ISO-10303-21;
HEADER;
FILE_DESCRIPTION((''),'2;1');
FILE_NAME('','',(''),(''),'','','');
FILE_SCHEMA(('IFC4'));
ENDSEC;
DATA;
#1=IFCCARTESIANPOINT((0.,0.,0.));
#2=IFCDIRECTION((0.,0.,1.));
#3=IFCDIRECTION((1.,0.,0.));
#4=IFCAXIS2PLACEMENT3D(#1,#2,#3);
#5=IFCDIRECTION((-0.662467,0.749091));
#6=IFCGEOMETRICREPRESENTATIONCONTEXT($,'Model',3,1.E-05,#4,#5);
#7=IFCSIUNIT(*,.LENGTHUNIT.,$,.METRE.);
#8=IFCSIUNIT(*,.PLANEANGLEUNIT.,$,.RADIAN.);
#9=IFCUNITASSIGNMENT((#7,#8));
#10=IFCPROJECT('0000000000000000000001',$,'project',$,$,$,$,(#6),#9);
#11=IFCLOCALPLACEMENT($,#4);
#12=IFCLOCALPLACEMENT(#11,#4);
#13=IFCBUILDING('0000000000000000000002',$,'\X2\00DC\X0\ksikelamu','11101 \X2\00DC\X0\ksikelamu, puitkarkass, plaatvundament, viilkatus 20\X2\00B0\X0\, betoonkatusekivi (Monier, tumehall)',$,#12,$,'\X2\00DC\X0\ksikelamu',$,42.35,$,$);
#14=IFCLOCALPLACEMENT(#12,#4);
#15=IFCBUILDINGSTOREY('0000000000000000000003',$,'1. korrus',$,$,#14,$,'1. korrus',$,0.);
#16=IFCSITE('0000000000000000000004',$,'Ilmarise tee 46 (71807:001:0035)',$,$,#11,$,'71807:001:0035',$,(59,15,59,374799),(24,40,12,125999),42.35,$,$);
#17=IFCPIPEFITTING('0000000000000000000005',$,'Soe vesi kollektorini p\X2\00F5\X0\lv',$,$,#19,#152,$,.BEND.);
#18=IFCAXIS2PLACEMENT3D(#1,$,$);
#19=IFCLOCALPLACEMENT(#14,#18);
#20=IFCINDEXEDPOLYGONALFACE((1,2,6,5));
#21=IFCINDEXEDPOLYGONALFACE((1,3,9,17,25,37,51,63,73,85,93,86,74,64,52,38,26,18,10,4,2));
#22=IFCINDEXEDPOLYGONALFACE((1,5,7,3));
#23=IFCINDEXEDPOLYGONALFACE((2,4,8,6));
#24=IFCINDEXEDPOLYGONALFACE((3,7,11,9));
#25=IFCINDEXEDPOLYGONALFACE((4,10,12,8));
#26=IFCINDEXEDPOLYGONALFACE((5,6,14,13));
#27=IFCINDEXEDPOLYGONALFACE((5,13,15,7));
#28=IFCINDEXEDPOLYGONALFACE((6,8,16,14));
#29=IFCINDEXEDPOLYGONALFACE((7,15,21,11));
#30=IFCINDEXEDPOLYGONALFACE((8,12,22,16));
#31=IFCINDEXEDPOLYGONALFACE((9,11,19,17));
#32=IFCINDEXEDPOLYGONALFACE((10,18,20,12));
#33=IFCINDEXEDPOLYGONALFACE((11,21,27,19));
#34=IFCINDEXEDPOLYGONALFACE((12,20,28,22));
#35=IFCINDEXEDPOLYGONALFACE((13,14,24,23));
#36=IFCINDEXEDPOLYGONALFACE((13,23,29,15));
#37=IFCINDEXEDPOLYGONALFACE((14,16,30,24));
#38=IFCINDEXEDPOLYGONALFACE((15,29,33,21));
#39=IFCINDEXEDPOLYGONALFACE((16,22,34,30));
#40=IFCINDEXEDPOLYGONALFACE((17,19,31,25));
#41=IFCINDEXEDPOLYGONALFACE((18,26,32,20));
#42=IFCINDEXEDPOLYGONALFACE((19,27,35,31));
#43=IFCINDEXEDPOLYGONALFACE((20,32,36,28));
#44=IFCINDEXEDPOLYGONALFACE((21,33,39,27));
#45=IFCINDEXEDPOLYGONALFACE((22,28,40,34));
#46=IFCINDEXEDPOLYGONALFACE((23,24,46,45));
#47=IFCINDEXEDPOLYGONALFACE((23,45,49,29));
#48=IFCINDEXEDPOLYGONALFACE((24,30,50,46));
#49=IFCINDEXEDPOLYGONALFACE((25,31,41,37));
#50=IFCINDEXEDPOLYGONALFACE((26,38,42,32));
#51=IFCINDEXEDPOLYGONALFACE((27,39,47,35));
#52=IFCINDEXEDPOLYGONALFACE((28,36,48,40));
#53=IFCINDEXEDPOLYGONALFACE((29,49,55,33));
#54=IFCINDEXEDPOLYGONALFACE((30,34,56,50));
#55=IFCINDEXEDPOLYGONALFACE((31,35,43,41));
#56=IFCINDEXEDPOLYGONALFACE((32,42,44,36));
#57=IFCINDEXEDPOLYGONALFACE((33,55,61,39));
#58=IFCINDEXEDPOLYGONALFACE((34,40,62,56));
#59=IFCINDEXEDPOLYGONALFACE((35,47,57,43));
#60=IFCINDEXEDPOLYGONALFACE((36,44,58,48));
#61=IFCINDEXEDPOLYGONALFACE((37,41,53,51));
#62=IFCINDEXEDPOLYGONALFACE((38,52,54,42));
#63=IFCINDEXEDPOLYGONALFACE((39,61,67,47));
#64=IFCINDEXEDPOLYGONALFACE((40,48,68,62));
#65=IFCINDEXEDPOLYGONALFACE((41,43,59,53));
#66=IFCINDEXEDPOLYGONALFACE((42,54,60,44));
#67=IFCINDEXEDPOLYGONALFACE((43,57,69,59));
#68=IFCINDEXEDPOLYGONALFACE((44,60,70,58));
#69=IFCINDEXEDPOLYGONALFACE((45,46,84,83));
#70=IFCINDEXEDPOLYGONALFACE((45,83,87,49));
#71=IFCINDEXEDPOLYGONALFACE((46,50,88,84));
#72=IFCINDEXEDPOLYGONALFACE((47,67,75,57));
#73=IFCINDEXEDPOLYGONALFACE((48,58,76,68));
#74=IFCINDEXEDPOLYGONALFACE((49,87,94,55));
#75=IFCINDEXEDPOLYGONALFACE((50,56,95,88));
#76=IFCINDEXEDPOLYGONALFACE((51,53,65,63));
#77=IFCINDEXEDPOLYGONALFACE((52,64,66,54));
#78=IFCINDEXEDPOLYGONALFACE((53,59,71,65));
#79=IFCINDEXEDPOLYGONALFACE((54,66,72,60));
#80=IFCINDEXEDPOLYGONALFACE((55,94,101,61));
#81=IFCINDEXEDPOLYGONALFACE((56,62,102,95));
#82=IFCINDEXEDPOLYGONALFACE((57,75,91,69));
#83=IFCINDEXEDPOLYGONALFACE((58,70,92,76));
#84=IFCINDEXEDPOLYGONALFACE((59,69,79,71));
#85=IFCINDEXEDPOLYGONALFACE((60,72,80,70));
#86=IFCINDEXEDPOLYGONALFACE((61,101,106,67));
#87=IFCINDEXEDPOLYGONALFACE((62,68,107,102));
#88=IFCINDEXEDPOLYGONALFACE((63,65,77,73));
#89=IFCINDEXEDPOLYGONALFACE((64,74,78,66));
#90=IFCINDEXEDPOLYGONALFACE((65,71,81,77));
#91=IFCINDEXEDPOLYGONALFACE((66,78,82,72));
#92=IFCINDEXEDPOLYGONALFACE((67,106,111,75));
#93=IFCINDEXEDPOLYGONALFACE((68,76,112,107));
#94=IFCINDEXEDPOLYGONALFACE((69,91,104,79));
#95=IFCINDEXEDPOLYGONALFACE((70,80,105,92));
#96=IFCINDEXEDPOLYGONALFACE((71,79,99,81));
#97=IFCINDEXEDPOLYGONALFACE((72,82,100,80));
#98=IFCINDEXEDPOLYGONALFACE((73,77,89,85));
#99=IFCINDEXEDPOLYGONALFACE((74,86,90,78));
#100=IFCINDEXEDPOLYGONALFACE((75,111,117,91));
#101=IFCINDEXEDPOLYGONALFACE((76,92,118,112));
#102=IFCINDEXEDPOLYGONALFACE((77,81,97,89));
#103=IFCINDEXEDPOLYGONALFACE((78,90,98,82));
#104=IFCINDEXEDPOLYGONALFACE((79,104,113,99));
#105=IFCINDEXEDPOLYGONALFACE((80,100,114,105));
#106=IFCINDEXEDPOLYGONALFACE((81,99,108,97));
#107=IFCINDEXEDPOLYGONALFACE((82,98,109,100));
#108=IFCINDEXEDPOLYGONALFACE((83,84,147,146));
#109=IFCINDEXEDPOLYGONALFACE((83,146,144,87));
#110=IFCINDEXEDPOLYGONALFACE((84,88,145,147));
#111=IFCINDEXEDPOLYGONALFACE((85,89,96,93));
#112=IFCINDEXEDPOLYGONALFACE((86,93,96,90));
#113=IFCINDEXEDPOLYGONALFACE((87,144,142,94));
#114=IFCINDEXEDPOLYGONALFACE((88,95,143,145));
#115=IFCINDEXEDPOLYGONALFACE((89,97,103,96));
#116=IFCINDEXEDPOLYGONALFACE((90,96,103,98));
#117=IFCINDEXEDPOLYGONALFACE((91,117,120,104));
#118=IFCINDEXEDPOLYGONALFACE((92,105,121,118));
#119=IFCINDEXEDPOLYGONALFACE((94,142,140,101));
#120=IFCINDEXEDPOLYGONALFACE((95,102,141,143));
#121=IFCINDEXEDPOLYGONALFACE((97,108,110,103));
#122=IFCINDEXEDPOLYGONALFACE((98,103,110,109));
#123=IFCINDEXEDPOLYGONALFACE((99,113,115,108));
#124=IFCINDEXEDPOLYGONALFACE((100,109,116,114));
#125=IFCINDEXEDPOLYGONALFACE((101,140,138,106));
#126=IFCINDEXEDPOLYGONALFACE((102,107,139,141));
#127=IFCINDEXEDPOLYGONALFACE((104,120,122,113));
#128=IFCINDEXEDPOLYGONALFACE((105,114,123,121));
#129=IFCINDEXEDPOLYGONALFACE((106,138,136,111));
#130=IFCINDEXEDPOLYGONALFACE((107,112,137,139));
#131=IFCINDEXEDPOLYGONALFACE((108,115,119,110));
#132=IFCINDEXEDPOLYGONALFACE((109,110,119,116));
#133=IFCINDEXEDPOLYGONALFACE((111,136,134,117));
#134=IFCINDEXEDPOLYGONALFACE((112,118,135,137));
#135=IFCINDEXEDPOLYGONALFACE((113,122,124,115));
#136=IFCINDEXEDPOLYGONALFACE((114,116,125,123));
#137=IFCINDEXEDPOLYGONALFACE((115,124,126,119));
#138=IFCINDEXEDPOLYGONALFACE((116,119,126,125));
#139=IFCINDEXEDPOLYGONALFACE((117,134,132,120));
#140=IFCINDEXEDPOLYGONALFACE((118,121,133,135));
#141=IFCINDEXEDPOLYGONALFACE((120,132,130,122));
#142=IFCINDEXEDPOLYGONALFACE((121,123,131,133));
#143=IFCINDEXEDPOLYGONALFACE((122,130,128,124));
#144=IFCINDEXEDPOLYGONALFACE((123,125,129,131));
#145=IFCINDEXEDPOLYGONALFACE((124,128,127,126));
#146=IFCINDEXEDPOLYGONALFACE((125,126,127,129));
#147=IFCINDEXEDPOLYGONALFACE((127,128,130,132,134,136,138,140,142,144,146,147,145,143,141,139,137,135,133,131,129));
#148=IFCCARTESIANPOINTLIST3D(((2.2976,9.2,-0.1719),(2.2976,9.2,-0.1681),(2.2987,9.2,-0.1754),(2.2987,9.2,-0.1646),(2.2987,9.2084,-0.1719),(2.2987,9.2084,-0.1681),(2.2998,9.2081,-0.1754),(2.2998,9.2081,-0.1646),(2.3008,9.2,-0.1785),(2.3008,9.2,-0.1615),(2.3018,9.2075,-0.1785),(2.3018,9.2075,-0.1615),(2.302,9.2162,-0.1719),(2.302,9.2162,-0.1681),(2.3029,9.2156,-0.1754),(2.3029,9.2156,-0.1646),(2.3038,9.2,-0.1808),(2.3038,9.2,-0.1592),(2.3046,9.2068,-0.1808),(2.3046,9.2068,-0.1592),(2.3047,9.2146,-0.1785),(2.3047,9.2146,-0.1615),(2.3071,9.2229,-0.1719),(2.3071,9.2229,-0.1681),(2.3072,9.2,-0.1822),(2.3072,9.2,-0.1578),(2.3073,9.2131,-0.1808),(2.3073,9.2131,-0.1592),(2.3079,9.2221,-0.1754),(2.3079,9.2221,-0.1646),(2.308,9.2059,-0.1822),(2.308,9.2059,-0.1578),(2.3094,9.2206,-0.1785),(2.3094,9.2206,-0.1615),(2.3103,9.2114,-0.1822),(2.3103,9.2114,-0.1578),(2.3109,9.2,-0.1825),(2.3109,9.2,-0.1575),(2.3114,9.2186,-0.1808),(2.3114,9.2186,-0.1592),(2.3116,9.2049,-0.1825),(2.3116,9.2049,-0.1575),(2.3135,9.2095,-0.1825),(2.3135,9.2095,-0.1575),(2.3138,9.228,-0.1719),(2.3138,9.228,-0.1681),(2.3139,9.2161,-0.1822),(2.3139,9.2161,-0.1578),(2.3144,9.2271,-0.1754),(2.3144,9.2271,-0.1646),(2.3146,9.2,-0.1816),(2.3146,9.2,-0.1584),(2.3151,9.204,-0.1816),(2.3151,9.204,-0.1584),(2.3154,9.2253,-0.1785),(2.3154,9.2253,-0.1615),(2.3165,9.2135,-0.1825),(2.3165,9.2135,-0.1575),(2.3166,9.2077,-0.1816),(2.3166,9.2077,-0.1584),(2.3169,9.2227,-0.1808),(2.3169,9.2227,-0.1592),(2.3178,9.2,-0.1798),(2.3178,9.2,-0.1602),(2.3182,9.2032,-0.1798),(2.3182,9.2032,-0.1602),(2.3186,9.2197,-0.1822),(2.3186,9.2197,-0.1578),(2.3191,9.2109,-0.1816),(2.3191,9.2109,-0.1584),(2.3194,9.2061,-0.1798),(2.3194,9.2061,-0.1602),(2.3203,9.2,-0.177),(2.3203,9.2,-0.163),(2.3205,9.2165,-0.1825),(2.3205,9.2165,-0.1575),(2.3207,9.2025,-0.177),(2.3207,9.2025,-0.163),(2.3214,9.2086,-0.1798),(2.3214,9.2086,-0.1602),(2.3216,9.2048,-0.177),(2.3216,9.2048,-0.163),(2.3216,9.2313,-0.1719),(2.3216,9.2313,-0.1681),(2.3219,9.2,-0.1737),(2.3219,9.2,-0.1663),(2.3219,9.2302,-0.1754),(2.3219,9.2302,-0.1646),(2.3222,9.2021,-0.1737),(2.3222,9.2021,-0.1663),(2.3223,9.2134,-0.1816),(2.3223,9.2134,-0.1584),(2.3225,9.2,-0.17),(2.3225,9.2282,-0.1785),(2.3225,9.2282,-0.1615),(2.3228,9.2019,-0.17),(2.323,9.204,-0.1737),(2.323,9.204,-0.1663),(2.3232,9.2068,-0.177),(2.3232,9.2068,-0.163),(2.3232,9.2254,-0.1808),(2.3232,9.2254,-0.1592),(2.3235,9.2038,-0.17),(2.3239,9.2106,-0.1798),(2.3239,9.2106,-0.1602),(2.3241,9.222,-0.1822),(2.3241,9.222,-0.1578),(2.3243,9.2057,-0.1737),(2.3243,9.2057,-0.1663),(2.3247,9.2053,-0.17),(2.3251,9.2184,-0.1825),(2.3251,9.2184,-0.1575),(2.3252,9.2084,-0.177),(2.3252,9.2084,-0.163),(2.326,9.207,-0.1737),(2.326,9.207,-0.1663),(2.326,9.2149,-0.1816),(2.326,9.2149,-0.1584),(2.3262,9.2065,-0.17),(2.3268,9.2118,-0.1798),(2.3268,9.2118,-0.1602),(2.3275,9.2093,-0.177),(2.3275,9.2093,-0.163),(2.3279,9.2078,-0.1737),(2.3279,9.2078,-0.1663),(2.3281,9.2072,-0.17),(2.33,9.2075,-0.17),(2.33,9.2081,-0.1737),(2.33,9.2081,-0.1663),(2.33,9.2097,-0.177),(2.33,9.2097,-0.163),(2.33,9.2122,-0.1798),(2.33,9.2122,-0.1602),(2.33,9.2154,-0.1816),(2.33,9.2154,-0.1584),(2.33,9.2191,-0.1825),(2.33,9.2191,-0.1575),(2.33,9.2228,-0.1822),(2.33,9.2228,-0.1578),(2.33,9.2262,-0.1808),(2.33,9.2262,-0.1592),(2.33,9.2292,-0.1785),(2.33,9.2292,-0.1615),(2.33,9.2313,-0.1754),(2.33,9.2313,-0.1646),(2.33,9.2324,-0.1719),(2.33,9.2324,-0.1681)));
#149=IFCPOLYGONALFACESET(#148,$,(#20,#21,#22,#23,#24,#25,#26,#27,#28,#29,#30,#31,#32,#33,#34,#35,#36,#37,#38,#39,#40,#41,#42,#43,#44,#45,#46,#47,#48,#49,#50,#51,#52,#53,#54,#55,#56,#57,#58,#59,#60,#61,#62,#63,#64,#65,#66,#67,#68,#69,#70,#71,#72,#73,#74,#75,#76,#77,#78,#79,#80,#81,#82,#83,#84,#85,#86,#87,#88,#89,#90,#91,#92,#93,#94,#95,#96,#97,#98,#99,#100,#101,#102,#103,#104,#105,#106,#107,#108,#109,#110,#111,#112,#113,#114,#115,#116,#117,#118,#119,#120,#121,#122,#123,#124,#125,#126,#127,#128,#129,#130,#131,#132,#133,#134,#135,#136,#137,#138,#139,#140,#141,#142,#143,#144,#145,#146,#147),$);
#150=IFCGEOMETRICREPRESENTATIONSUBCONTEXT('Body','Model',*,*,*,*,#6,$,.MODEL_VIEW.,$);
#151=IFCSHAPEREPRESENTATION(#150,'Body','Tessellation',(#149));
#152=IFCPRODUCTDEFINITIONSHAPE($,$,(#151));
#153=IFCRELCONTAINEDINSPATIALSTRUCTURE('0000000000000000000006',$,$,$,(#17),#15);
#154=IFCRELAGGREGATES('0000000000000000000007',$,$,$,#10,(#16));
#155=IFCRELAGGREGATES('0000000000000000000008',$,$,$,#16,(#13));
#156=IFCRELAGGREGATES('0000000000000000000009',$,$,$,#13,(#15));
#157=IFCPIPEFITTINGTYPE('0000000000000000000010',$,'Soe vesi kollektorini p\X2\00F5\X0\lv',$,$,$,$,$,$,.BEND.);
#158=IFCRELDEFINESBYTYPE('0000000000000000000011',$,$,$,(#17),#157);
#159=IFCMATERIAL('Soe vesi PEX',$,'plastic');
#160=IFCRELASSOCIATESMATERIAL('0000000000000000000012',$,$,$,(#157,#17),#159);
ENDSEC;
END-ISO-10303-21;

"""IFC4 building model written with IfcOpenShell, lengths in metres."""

from ifc_helpers import new_model, entity, si_unit, direction, frame, origin_with_axes, place, context, subcontext, project, spatial, material, type_object, element, save


model = new_model("IFC4")

# Units and contexts
model_context = context("Model", 3, precision=1e-05, world=origin_with_axes(), true_north=direction((-0.662467, 0.749091)))
body_context = subcontext(model_context, "Body", "Model", "MODEL_VIEW")
ifc_project = project(units=[si_unit("LENGTHUNIT", "METRE"), si_unit("PLANEANGLEUNIT", "RADIAN")], contexts=[model_context])

# Site, building, storey
site_placement = place(None, origin_with_axes())
site = spatial("IfcSite", under=ifc_project, at=site_placement, Name="Ilmarise tee 46 (71807:001:0035)", LongName="71807:001:0035", RefLatitude=(59, 15, 59, 374799), RefLongitude=(24, 40, 12, 125999), RefElevation=42.35)
building_placement = place(site_placement, origin_with_axes())
building = spatial("IfcBuilding", under=site, at=building_placement, Name="Üksikelamu", Description="11101 Üksikelamu, puitkarkass, plaatvundament, viilkatus 20°, betoonkatusekivi (Monier, tumehall)", LongName="Üksikelamu", ElevationOfRefHeight=42.35)
storey_placement = place(building_placement, origin_with_axes())
storey = spatial("IfcBuildingStorey", under=building, at=storey_placement, Name="1. korrus", LongName="1. korrus", Elevation=0.0)

# Pipe fitting
ifc_material_1 = material(Name="Soe vesi PEX", Category="plastic")
pipe_fitting_type_1 = type_object("IfcPipeFittingType", Name="Soe vesi kollektorini põlv", PredefinedType="BEND", material=ifc_material_1)
pipe_fitting_1_placement = place(storey_placement, frame((2.31, 9.22, -0.17), z_axis=(0.0, 0.0, 1.0), x_axis=(1.0, 0.0, 0.0)))
element("IfcPipeFitting", 1, at=pipe_fitting_1_placement, inside=storey, type_object=pipe_fitting_type_1, material=ifc_material_1, Name="Soe vesi kollektorini põlv", PredefinedType="BEND", context=body_context, shape_type="SweptSolid", body=[
    entity("IfcRevolvedAreaSolid", entity("IfcCircleProfileDef", "AREA", None, None, 0.0125), entity("IfcAxis2Placement3D", entity("IfcCartesianPoint", [0.02, 0.0, 0.0]), entity("IfcDirection", [-1.0, 0.0, 0.0]), entity("IfcDirection", [0.0, -1.0, 0.0])), entity("IfcAxis1Placement", entity("IfcCartesianPoint", [0.02, 0.0, 0.0]), entity("IfcDirection", [0.0, 1.0, 0.0])), 1.570796),
])

save(model, "model.ifc")
